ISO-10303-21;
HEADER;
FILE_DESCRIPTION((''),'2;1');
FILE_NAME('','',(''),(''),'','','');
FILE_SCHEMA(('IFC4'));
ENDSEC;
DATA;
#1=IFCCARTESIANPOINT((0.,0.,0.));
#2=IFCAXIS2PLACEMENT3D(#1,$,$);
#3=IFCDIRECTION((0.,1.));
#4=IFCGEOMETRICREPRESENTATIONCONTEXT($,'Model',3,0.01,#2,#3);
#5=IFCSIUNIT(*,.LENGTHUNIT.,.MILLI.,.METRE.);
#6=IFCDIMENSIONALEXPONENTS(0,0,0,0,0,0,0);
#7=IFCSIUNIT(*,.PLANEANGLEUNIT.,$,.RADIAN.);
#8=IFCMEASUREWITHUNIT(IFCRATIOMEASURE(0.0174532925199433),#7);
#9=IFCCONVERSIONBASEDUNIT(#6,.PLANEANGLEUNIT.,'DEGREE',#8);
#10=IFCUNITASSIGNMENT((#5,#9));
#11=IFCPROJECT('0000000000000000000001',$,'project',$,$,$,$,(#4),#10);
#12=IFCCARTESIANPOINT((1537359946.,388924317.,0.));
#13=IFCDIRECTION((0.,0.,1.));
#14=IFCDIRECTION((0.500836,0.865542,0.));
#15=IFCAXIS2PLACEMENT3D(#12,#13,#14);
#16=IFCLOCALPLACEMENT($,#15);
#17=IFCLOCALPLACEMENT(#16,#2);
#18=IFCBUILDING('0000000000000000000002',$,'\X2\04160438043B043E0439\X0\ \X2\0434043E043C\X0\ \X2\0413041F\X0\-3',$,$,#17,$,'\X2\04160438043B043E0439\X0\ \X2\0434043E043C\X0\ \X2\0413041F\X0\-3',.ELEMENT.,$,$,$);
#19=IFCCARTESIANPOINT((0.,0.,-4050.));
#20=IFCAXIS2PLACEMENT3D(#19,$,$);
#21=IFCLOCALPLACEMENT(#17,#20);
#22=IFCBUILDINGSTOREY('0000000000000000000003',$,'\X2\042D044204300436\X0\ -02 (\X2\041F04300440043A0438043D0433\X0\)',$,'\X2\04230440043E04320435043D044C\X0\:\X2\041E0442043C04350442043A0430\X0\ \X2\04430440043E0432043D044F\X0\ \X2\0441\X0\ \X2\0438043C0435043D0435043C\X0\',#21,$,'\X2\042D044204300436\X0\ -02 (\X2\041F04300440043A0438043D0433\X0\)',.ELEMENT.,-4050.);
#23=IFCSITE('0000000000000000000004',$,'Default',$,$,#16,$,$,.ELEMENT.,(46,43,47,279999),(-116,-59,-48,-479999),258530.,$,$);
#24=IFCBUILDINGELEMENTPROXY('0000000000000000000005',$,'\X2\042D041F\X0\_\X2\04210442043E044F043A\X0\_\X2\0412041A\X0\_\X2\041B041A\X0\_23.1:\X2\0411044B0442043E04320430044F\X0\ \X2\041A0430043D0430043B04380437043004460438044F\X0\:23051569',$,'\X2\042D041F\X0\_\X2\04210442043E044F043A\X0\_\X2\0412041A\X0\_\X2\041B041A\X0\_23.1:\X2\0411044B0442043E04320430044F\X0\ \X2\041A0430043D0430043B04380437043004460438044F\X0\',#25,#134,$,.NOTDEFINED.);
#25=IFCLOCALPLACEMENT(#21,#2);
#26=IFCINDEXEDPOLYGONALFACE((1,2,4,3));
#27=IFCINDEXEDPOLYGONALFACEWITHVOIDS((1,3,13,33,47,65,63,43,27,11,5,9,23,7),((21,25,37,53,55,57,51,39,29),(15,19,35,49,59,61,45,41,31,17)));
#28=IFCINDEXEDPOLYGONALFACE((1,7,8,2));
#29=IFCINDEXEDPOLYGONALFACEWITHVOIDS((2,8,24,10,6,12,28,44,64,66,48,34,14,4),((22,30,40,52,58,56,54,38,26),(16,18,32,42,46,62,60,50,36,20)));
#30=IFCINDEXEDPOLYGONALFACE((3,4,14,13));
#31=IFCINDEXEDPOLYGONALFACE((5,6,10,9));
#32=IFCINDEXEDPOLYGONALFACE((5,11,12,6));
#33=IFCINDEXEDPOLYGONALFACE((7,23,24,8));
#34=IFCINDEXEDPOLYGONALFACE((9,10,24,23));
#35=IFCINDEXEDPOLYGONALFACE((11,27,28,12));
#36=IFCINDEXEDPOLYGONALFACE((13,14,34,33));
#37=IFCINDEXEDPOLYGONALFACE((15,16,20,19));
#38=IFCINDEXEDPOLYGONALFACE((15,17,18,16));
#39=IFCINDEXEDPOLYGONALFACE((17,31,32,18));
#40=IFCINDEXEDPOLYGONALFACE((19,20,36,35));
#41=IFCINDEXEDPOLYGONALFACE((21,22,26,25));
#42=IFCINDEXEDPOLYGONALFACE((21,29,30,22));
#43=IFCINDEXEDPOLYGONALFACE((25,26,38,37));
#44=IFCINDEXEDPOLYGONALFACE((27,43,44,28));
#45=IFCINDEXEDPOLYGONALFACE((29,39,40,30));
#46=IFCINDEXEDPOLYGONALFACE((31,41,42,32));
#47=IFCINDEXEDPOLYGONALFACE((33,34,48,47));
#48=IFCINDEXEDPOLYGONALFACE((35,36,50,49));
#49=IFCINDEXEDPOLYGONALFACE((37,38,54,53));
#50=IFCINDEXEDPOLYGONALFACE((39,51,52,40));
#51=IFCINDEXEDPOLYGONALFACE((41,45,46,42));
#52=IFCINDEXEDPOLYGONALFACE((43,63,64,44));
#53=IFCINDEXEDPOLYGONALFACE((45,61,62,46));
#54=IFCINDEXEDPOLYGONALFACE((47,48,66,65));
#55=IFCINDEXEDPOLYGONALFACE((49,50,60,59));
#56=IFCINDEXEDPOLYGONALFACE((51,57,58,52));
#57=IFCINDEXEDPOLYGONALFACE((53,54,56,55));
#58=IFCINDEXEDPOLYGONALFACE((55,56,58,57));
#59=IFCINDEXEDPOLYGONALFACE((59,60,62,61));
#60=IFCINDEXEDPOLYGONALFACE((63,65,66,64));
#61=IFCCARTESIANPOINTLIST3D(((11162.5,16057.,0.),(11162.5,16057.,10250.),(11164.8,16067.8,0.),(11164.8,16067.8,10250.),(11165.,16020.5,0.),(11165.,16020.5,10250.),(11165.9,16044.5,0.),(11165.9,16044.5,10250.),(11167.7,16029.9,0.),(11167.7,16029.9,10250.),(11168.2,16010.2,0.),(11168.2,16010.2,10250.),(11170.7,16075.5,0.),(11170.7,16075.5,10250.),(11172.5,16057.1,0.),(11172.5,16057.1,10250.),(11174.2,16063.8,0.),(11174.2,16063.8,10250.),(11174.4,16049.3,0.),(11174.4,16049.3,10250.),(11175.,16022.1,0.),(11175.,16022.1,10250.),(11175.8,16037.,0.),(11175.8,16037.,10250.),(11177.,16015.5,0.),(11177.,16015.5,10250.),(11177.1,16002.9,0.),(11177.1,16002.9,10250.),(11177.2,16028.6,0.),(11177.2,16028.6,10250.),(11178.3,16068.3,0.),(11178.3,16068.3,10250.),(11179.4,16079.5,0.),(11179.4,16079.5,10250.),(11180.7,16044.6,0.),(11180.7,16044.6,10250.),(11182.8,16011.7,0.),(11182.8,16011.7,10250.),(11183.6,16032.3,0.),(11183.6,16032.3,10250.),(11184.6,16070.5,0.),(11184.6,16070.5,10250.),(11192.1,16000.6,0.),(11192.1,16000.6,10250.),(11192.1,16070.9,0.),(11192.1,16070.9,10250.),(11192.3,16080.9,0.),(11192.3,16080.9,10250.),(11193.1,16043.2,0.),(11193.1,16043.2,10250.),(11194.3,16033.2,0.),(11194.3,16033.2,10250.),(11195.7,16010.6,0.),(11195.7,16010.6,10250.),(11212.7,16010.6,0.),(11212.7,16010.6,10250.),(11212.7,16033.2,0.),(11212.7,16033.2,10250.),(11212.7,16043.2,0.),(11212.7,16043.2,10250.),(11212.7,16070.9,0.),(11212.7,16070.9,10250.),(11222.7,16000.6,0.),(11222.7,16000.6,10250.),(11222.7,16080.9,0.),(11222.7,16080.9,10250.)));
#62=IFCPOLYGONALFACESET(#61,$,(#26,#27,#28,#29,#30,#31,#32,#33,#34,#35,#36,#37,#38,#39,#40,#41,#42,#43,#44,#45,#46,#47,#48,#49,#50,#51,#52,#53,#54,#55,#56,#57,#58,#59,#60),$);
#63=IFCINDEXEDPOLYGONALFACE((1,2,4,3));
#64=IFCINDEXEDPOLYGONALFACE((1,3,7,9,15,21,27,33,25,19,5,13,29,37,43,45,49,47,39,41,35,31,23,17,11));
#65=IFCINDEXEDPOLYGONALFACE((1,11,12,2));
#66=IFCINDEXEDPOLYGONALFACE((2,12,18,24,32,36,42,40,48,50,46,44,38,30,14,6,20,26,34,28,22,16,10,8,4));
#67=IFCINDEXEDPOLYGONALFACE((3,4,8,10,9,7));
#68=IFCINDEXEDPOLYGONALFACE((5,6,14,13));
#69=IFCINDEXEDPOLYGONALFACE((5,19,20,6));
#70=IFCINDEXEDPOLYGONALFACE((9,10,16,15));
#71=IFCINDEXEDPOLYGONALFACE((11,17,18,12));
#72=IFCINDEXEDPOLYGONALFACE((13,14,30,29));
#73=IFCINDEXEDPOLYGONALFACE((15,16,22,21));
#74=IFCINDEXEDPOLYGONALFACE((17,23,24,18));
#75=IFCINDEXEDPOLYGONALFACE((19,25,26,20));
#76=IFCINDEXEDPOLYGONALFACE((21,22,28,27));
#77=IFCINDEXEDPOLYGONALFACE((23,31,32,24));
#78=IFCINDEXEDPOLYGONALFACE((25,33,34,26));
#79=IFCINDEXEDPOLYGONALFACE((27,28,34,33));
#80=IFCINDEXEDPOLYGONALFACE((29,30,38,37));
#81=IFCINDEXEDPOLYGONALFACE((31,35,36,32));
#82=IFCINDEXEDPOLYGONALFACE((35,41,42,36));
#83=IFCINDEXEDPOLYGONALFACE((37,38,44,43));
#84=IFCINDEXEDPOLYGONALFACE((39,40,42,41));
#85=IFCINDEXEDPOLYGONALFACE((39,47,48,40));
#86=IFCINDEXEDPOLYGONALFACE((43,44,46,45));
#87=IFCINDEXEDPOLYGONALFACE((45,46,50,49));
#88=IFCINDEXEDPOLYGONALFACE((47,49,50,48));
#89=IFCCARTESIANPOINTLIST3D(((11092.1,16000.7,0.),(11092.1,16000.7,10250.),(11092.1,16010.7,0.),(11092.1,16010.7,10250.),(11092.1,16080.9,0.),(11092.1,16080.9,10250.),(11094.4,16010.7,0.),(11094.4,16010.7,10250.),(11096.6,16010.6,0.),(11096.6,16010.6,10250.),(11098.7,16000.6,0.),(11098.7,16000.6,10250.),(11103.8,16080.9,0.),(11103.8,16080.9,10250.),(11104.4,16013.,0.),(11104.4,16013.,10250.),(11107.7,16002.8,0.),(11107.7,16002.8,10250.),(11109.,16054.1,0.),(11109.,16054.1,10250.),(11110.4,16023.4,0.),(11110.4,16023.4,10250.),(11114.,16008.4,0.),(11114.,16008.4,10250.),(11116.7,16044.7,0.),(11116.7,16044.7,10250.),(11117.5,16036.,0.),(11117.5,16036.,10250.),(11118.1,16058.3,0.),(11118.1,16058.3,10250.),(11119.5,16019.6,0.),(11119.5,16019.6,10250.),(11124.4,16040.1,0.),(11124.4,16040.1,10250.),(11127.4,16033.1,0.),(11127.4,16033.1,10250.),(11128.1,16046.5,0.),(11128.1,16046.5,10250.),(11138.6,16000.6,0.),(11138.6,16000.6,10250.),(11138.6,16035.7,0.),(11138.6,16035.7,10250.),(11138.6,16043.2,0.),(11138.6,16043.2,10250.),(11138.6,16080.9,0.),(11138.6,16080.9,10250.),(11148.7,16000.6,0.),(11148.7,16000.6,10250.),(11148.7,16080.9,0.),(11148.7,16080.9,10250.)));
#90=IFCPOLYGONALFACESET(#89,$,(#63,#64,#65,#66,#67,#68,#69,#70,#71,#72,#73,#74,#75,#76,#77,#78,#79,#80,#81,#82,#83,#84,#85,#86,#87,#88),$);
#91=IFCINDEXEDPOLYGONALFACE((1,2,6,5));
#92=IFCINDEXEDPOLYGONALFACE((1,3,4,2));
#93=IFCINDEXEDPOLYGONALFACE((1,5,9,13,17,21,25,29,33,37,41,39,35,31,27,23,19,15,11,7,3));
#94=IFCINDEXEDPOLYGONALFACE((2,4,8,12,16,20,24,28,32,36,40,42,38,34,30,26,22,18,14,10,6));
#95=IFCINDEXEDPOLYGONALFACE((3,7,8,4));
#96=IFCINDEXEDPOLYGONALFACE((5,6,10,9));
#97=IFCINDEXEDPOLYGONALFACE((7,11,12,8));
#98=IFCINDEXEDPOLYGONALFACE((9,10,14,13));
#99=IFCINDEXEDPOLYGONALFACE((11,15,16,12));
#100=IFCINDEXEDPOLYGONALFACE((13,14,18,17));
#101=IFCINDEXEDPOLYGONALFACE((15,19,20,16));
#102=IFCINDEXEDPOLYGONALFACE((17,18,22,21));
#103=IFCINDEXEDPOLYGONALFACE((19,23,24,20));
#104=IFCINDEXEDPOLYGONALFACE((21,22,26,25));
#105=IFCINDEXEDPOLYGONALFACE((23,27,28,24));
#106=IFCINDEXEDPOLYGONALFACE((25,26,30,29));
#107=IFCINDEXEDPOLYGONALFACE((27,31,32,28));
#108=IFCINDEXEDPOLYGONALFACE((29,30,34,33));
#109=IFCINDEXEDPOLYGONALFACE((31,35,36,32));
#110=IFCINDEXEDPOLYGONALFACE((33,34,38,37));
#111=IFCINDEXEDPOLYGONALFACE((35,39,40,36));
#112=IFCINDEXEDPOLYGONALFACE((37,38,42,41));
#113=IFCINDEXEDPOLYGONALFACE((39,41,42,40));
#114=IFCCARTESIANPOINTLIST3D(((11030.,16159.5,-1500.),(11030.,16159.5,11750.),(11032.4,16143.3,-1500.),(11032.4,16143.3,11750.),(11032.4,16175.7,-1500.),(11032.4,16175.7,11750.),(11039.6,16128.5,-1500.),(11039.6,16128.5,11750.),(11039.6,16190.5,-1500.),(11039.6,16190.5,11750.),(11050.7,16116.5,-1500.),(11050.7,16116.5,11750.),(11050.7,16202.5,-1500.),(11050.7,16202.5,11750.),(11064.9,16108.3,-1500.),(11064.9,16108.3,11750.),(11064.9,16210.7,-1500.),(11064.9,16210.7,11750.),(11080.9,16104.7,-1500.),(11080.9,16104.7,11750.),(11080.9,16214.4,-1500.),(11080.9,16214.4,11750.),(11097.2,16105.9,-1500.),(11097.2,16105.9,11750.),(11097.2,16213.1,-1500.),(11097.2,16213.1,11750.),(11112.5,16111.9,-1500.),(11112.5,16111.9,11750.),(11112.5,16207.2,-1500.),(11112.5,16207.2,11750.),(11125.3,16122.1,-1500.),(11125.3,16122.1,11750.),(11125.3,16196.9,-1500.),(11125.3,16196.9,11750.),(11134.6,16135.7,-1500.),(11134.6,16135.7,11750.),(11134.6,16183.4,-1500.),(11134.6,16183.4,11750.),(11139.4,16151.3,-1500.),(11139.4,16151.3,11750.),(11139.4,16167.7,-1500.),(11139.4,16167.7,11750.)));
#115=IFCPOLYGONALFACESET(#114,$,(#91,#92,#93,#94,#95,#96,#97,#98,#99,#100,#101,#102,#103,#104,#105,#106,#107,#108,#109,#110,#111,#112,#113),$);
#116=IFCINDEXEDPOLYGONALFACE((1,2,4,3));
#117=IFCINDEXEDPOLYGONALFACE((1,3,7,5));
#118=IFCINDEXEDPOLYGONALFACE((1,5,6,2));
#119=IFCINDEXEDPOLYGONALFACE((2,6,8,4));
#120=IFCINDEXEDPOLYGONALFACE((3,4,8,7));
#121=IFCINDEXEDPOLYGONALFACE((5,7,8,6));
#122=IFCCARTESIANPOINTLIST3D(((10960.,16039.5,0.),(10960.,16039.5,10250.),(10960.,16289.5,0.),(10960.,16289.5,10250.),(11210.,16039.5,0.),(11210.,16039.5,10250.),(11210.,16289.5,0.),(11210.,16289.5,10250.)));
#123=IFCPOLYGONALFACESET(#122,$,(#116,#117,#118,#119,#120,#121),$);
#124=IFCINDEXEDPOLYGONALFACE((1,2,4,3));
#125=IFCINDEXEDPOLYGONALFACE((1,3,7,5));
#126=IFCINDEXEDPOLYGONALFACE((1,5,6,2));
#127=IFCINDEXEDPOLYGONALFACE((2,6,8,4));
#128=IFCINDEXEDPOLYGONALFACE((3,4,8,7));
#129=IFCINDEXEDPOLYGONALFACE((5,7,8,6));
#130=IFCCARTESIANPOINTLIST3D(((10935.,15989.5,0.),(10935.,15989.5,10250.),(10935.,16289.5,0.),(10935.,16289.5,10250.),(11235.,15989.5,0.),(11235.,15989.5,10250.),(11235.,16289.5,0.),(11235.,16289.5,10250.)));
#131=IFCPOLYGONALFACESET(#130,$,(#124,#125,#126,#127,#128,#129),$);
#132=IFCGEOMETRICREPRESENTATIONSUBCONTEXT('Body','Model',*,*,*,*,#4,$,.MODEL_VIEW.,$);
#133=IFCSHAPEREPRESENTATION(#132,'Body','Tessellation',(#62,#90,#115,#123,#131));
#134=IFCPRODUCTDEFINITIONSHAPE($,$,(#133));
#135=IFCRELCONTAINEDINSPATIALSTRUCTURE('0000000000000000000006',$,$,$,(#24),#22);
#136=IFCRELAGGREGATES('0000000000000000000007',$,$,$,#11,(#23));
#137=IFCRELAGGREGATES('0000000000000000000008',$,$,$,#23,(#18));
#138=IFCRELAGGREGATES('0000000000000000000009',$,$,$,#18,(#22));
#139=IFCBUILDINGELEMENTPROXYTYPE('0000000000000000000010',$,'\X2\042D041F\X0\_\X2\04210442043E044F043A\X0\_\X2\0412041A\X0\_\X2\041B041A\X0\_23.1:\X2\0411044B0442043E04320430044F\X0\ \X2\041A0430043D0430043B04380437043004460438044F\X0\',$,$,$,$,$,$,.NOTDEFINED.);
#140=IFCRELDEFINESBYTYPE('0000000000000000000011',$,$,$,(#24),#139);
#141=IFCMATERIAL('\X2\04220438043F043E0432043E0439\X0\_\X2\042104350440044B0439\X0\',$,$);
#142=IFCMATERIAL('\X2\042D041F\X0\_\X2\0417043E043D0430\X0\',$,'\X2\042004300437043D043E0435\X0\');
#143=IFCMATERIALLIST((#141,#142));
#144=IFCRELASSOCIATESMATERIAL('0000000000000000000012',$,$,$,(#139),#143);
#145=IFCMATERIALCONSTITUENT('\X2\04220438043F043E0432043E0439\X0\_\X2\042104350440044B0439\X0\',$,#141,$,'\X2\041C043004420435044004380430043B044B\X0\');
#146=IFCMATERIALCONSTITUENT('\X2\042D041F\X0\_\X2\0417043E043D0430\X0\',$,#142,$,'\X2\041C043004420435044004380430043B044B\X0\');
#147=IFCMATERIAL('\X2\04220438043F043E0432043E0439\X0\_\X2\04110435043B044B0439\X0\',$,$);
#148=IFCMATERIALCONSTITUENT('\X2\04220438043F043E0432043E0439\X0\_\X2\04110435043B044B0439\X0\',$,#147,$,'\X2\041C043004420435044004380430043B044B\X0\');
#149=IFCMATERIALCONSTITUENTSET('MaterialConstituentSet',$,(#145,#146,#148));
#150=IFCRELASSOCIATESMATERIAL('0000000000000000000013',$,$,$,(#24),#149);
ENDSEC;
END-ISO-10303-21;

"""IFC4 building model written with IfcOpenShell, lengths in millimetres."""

from ifc_helpers import new_model, entity, si_unit, converted_unit, direction, frame, frame_2d, origin, place, context, subcontext, project, spatial, polyline, rectangle, circle, outline, extrude, source, transform, mapped, material, material_list, constituent, constituent_set, type_object, type_shapes, element, save


model = new_model("IFC4")

# Units and contexts
model_context = context("Model", 3, precision=0.01, world=origin(), true_north=direction((0.0, 1.0)))
body_context = subcontext(model_context, "Body", "Model", "MODEL_VIEW")
ifc_project = project(units=[si_unit("LENGTHUNIT", "METRE", prefix="MILLI"), converted_unit("PLANEANGLEUNIT", "DEGREE", entity("IfcRatioMeasure", 0.0174532925199433), si_unit("PLANEANGLEUNIT", "RADIAN"), dimensions=[0, 0, 0, 0, 0, 0, 0])], contexts=[model_context])

# Site, building, storey
site_placement = place(None, frame((1537359946.0, 388924317.0, 0.0), z_axis=(0.0, 0.0, 1.0), x_axis=(0.500836, 0.865542, 0.0)))
site = spatial("IfcSite", under=ifc_project, at=site_placement, Name="Default", CompositionType="ELEMENT", RefLatitude=(46, 43, 47, 279999), RefLongitude=(-116, -59, -48, -479999), RefElevation=258530.0)
building_placement = place(site_placement, origin())
building = spatial("IfcBuilding", under=site, at=building_placement, Name="Жилой дом ГП-3", LongName="Жилой дом ГП-3", CompositionType="ELEMENT")
storey_placement = place(building_placement, frame((0.0, 0.0, -4050.0)))
storey = spatial("IfcBuildingStorey", under=building, at=storey_placement, Name="Этаж -02 (Паркинг)", ObjectType="Уровень:Отметка уровня с именем", LongName="Этаж -02 (Паркинг)", CompositionType="ELEMENT", Elevation=-4050.0)

# Building element proxy
ifc_material_1 = material(Name="ЭП_Зона", Category="Разное")
ifc_material_2 = material(Name="Типовой_Белый")
ifc_material_3 = material(Name="Типовой_Серый")
ifc_constituent_1 = constituent(ifc_material_3, Name="Типовой_Серый", Category="Материалы")
ifc_constituent_2 = constituent(ifc_material_1, Name="ЭП_Зона", Category="Материалы")
ifc_constituent_3 = constituent(ifc_material_2, Name="Типовой_Белый", Category="Материалы")
ifc_constituent_set_1 = constituent_set(constituents=[ifc_constituent_1, ifc_constituent_2, ifc_constituent_3], Name="MaterialConstituentSet")
ifc_material_list_1 = material_list([ifc_material_3, ifc_material_1])
building_element_proxy_type_1 = type_object("IfcBuildingElementProxyType", Name="ЭП_Стояк_ВК_ЛК_23.1:Бытовая Канализация", PredefinedType="NOTDEFINED", material=ifc_material_list_1)
shared_shape_1 = source(origin(), body_context, "Body", "SweptSolid", [
    extrude(outline(polyline([(-42.2, -39.0), (-11.8, -39.0), (1.1, -37.6), (9.8, -33.5), (15.7, -25.8), (18.0, -15.0), (14.6, -2.5), (4.7, 5.0), (12.8, 12.1), (15.5, 21.5), (12.3, 31.8), (3.4, 39.0), (-11.6, 41.4), (-42.2, 41.4), (-42.2, -39.0)]), holes=[polyline([(-32.2, 8.8), (-32.2, 31.4), (-15.2, 31.4), (-2.3, 30.3), (3.5, 26.4), (5.5, 19.9), (3.3, 13.3), (-3.1, 9.6), (-13.9, 8.8), (-32.2, 8.8)]), polyline([(-32.2, -28.9), (-32.2, -1.3), (-12.6, -1.3), (-0.2, -2.6), (6.1, -7.3), (8.0, -15.1), (6.3, -21.9), (2.2, -26.3), (-4.1, -28.5), (-11.6, -28.9), (-32.2, -28.9)])]), frame((54.5, -52.4, -4050.0)), (0.0, 0.0, 1.0), 10250.0),
    extrude(outline(polyline([(-32.1, -31.9), (48.3, -31.9), (48.3, -21.8), (10.6, -21.8), (13.8, -11.4), (25.6, -1.3), (48.3, 13.0), (48.3, 24.6), (21.4, 7.7), (12.0, 0.1), (7.4, -7.7), (3.3, -0.7), (-9.3, 6.4), (-19.7, 12.3), (-22.1, 20.2), (-22.0, 22.4), (-22.0, 24.6), (-32.0, 24.6), (-32.1, 18.0), (-29.9, 9.0), (-24.3, 2.8), (-13.1, -2.8), (0.4, -10.6), (3.0, -21.8), (-32.1, -21.8), (-32.1, -31.9)])), frame((118.2, -43.1, -4050.0), z_axis=(0.0, 0.0, 1.0), x_axis=(0.0, -1.0, 0.0)), (0.0, 0.0, 1.0), 10250.0),
    extrude(circle(Radius=55.0, at=frame_2d((0.0, 0.0), x_axis=(1.0, 0.0))), frame((150.0, -170.0, -5550.0)), (0.0, 0.0, 1.0), 13250.0),
    extrude(rectangle(XDim=250.0, YDim=250.0, at=frame_2d((0.0, 0.0), x_axis=(1.0, 0.0))), frame((150.0, -175.0, -4050.0)), (0.0, 0.0, 1.0), 10250.0),
    extrude(rectangle(XDim=300.0, YDim=300.0, at=frame_2d((0.0, 0.0), x_axis=(1.0, 0.0))), frame((150.0, -150.0, -4050.0)), (0.0, 0.0, 1.0), 10250.0),
])
type_shapes(building_element_proxy_type_1, [shared_shape_1])
proxy_1_placement = place(storey_placement, frame((11235.0, 15989.5, 4050.0), z_axis=(0.0, 0.0, 1.0), x_axis=(-1.0, 0.0, 0.0)))
element("IfcBuildingElementProxy", 1, at=proxy_1_placement, inside=storey, type_object=building_element_proxy_type_1, material=ifc_constituent_set_1, Name="ЭП_Стояк_ВК_ЛК_23.1:Бытовая Канализация:23051569", ObjectType="ЭП_Стояк_ВК_ЛК_23.1:Бытовая Канализация", PredefinedType="NOTDEFINED", context=body_context, shape_type="MappedRepresentation", body=[
    mapped(shared_shape_1, transform((0.0, 0.0, 0.0), scale=1.0)),
])

save(model, "model.ifc")
